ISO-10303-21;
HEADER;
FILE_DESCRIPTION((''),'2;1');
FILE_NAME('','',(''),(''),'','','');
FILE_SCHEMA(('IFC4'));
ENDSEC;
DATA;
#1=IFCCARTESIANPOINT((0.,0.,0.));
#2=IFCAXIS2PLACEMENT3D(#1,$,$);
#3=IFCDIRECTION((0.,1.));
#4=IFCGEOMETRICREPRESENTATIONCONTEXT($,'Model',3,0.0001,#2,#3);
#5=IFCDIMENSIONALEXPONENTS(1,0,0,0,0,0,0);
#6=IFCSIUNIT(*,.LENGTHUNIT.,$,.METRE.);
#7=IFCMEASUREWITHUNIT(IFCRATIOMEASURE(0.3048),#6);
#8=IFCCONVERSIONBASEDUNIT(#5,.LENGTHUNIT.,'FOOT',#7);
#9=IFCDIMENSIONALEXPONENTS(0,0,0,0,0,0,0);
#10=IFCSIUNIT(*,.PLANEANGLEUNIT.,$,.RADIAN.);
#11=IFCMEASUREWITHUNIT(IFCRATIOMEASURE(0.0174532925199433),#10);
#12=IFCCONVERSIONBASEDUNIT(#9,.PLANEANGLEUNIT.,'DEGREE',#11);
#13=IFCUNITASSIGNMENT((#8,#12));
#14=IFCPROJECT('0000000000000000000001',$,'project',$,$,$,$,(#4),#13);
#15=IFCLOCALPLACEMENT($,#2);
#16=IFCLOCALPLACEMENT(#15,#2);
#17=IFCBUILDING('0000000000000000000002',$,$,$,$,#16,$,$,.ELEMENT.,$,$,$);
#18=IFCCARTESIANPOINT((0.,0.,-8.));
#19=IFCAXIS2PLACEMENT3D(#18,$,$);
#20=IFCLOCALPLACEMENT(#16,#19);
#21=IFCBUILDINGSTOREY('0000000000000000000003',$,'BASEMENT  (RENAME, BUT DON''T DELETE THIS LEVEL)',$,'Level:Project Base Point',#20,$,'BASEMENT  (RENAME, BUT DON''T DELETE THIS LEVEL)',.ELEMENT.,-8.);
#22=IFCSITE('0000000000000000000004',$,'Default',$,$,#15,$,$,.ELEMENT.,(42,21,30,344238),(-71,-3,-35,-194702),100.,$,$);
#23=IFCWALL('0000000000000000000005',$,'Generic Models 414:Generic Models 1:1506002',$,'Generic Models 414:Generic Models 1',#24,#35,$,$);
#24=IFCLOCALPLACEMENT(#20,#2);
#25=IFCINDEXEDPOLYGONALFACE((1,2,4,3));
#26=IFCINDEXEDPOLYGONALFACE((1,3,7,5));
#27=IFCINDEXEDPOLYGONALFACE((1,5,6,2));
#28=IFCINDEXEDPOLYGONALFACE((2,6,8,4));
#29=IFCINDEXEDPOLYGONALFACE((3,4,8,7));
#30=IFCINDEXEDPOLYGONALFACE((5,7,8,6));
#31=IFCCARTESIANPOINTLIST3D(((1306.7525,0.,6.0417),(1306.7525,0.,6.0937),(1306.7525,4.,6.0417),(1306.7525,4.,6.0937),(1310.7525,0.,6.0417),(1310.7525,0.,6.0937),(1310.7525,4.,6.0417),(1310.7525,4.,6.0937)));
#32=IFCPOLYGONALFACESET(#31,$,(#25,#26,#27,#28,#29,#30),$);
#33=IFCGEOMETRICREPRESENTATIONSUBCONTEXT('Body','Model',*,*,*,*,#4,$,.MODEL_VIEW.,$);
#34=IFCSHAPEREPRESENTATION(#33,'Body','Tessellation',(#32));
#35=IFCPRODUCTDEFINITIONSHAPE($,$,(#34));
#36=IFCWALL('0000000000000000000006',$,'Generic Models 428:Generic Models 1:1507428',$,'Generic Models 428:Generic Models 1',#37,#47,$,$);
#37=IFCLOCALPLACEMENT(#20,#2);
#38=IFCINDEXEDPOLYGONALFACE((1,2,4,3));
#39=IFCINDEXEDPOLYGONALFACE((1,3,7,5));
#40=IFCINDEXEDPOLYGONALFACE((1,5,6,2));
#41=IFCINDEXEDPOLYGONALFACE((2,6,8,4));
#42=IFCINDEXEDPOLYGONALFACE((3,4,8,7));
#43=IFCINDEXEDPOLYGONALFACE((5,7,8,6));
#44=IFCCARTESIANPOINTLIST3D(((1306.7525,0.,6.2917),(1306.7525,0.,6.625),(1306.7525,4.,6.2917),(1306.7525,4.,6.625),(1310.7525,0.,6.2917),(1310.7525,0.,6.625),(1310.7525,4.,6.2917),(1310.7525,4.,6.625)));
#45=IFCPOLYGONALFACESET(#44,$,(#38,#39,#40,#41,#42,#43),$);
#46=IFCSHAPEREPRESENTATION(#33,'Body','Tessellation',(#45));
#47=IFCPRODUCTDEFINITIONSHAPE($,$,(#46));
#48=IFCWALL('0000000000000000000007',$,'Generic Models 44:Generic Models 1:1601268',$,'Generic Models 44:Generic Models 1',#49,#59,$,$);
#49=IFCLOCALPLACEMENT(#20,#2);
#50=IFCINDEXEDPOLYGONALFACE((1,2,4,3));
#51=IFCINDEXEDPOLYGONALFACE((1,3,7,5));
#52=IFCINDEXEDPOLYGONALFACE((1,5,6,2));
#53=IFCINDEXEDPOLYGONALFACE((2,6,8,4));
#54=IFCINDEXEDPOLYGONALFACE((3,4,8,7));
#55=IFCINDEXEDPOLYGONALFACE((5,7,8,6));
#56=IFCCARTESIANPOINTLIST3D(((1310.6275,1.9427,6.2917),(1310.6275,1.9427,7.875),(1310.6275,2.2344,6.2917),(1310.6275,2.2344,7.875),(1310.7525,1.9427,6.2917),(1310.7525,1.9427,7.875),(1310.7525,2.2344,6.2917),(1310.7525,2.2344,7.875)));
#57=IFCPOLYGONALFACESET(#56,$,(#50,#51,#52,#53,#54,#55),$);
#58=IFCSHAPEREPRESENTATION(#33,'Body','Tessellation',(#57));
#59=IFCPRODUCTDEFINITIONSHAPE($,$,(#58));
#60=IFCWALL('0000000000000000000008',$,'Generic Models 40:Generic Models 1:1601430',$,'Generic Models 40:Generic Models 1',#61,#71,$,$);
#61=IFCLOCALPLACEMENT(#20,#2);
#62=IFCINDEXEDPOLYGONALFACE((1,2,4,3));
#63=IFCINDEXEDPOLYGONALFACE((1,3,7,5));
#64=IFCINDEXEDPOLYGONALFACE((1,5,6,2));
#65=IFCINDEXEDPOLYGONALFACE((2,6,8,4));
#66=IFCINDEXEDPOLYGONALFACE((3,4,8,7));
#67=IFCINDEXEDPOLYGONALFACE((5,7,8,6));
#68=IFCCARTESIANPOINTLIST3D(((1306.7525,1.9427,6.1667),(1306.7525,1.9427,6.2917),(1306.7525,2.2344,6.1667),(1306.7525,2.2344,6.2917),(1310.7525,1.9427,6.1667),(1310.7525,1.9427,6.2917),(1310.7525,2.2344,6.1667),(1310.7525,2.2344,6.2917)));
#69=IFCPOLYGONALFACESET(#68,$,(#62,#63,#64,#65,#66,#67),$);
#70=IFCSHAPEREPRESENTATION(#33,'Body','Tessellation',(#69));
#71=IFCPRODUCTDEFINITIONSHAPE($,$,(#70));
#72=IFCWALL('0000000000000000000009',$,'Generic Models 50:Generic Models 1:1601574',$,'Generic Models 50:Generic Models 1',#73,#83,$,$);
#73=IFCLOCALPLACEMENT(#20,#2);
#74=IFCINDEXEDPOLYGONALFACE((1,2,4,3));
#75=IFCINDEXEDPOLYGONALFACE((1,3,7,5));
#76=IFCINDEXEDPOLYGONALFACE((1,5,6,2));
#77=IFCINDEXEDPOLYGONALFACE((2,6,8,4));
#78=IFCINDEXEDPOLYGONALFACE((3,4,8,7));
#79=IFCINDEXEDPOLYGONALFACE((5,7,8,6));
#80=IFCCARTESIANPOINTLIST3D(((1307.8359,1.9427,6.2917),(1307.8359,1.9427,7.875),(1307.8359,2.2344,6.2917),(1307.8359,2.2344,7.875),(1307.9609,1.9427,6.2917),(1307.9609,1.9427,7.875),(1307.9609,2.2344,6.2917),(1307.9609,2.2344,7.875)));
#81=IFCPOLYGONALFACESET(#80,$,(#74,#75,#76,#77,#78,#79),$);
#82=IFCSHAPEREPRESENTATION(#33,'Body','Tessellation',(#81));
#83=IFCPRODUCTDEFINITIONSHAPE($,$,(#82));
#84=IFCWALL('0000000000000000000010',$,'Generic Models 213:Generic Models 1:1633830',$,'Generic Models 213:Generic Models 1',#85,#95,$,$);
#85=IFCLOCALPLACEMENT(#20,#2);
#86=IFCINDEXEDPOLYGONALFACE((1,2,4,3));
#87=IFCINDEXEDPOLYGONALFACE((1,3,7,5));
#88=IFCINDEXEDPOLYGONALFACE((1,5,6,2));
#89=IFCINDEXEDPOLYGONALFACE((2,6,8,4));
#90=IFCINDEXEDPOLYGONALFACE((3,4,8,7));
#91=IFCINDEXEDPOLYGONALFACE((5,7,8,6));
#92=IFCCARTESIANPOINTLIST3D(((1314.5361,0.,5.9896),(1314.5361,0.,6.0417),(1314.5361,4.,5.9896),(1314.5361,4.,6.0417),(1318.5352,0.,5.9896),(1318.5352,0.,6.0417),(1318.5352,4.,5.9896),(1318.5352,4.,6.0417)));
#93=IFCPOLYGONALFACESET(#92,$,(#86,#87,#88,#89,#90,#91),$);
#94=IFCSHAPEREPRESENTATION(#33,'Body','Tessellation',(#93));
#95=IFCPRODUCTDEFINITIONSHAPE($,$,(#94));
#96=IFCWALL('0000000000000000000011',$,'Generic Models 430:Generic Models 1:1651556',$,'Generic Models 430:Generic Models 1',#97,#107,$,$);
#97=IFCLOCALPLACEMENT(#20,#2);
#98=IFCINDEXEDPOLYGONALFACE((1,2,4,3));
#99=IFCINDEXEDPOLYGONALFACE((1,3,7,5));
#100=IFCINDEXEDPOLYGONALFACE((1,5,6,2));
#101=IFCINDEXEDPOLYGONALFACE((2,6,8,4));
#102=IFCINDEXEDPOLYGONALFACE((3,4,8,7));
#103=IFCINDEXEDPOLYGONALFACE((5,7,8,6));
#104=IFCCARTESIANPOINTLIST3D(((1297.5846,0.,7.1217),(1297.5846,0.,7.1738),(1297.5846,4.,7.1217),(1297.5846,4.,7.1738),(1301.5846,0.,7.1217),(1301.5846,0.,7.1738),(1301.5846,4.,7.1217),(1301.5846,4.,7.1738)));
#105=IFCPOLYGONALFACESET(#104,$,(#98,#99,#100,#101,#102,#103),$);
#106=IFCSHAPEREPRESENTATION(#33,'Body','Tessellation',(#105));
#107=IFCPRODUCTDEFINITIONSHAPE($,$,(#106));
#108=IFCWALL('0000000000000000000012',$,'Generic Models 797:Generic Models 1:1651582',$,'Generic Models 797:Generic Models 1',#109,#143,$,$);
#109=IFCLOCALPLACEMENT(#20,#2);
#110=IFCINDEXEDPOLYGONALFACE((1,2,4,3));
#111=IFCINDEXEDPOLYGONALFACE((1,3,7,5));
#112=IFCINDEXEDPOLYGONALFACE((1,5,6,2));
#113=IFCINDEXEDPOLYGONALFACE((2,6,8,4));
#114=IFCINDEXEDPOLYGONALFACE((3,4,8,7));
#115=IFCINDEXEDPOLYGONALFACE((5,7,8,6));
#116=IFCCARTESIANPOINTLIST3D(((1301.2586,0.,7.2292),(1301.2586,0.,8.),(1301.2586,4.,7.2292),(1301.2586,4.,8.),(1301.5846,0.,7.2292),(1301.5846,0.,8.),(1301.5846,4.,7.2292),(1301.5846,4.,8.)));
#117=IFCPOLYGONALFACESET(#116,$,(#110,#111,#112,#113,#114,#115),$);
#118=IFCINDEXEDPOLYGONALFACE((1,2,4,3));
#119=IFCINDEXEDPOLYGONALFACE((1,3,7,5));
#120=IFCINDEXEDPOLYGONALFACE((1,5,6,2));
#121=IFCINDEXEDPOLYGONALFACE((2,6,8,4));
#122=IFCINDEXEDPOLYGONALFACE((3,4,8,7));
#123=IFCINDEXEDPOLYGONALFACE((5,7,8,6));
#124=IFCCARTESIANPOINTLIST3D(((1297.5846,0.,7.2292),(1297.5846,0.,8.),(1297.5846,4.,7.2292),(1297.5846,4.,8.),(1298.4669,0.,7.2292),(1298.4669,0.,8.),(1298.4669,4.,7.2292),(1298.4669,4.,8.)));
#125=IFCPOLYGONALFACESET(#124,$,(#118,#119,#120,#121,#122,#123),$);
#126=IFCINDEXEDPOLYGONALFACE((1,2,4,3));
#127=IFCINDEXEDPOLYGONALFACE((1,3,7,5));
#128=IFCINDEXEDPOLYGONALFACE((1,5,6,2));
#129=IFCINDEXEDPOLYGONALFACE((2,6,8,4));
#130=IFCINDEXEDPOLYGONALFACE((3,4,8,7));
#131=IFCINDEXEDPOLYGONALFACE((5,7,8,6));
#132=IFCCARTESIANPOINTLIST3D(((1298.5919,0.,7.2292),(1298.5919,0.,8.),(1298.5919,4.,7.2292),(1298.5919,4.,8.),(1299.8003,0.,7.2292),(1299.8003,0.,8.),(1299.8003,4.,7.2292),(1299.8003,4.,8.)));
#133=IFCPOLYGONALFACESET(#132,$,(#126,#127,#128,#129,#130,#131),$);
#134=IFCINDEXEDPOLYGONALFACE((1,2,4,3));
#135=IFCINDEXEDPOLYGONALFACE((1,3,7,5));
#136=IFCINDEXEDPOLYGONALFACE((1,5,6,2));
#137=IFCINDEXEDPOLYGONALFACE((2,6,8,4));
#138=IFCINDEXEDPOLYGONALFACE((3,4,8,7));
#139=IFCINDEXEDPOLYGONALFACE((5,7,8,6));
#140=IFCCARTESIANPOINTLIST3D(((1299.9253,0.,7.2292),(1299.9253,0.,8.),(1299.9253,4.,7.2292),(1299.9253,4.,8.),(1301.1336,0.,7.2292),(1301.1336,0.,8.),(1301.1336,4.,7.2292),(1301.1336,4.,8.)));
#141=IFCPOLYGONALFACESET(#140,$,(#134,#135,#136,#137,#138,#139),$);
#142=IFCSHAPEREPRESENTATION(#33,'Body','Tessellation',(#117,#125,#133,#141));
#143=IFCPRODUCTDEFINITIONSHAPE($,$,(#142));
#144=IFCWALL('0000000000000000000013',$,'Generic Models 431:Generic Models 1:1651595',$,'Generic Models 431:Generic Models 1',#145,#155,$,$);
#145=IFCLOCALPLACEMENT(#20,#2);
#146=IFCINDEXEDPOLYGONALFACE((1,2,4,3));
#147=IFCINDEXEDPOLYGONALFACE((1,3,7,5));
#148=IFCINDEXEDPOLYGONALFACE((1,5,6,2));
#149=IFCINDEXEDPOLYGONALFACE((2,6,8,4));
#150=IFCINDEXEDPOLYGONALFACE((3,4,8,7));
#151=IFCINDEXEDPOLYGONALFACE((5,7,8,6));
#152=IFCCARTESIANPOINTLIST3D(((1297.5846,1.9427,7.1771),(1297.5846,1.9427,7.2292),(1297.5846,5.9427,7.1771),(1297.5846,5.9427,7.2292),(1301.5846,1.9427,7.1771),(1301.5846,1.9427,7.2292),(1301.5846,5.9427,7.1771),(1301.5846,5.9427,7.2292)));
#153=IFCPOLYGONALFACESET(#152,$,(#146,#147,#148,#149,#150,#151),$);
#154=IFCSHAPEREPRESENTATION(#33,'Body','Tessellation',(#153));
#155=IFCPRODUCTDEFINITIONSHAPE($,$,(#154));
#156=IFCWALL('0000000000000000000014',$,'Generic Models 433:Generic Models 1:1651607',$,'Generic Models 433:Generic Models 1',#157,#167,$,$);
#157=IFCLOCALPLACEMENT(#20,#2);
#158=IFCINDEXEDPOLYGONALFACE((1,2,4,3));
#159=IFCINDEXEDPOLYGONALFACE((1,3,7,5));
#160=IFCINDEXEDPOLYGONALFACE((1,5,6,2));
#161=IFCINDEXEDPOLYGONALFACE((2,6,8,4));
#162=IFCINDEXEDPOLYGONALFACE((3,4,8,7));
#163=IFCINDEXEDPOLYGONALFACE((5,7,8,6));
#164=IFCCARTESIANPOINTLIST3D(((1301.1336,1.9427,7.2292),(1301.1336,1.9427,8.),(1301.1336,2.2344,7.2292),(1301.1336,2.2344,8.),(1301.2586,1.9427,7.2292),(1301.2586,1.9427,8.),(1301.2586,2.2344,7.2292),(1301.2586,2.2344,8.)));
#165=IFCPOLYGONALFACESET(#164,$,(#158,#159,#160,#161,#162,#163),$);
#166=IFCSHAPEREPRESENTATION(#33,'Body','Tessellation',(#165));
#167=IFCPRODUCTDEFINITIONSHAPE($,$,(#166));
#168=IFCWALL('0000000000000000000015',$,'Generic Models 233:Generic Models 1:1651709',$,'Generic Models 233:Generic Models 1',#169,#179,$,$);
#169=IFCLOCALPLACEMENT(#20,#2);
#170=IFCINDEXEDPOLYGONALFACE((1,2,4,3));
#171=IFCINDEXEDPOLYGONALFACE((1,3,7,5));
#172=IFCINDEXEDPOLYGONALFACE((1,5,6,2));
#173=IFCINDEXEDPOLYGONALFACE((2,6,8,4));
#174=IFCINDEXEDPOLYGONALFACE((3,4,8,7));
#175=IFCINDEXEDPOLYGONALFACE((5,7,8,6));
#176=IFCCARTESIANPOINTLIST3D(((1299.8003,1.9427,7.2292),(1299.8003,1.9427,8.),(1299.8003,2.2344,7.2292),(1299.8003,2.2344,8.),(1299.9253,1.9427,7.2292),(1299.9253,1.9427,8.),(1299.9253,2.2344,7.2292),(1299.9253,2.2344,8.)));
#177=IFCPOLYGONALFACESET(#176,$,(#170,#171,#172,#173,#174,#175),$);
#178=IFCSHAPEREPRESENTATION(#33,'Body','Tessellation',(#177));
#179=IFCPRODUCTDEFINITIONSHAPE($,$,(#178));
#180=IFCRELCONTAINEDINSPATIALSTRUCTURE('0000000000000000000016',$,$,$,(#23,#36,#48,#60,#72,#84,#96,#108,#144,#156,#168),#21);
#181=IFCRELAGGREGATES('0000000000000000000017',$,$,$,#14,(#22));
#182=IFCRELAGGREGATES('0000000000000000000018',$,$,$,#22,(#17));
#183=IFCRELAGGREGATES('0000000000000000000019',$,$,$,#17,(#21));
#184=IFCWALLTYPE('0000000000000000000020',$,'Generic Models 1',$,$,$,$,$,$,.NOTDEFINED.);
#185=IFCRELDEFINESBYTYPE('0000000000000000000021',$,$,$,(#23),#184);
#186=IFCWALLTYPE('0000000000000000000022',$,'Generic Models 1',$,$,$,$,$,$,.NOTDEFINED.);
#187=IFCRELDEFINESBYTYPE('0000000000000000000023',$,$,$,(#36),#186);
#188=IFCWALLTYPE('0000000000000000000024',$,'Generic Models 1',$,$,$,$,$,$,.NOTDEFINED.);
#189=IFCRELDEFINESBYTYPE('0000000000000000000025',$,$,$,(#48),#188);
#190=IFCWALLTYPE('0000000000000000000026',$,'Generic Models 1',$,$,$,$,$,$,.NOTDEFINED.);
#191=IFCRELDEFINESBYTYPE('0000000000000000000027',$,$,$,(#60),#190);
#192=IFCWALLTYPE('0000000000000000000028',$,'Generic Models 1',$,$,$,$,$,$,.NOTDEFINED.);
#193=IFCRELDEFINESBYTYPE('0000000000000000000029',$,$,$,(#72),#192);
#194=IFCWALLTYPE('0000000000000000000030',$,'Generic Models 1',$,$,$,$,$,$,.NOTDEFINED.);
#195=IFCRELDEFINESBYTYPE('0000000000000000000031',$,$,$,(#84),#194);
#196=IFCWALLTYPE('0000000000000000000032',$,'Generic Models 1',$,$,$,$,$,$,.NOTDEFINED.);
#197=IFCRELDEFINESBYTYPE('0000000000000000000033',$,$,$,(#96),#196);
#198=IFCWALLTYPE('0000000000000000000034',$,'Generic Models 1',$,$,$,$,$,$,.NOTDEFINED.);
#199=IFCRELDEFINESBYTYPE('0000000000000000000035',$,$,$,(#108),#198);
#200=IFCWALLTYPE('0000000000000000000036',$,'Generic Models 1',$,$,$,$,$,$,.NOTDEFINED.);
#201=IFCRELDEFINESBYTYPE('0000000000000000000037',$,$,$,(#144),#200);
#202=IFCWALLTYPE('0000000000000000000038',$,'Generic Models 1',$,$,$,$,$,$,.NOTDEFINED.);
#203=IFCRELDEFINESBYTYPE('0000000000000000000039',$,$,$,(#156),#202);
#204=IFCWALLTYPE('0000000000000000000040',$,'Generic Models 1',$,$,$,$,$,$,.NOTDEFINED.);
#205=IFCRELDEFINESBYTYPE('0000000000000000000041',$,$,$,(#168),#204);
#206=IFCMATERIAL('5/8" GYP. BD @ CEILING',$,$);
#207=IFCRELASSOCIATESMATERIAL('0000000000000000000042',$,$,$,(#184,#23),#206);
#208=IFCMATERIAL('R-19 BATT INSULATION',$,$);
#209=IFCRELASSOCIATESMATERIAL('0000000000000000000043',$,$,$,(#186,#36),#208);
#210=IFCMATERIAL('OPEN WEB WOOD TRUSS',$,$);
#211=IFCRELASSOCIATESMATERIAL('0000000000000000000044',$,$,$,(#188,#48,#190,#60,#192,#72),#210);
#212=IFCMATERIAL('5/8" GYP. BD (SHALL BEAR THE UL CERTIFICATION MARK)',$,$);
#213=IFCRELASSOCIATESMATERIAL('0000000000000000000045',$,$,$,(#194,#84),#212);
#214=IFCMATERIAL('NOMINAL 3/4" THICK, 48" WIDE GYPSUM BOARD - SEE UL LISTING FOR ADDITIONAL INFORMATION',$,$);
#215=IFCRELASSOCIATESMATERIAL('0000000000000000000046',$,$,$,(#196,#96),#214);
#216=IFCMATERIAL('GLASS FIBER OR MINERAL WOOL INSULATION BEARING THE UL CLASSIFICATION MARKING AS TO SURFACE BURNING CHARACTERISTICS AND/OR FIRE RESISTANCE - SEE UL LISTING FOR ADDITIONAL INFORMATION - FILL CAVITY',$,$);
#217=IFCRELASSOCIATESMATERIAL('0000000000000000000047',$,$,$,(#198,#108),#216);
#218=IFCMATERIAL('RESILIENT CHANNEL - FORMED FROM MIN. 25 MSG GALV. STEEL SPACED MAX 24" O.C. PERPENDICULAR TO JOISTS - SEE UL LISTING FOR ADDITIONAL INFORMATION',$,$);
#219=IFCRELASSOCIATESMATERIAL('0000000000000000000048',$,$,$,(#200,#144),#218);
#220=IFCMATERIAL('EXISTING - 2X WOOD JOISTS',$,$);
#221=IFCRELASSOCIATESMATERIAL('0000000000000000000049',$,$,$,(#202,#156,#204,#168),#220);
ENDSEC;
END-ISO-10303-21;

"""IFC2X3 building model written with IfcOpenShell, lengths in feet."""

from ifc_helpers import new_model, entity, si_unit, converted_unit, direction, frame, frame_2d, origin, origin_2d_with_axis, place, context, subcontext, project, spatial, rectangle, extrude, material, type_object, element, save


model = new_model("IFC2X3")

# Units and contexts
model_context = context("Model", 3, precision=0.0001, world=origin(), true_north=direction((0.0, 1.0)))
body_context = subcontext(model_context, "Body", "Model", "MODEL_VIEW")
ifc_project = project(units=[converted_unit("LENGTHUNIT", "FOOT", entity("IfcRatioMeasure", 0.3048), si_unit("LENGTHUNIT", "METRE"), dimensions=[1, 0, 0, 0, 0, 0, 0]), converted_unit("PLANEANGLEUNIT", "DEGREE", entity("IfcRatioMeasure", 0.0174532925199433), si_unit("PLANEANGLEUNIT", "RADIAN"), dimensions=[0, 0, 0, 0, 0, 0, 0])], contexts=[model_context])

# Site, building, storey
site_placement = place(None, origin())
site = spatial("IfcSite", under=ifc_project, at=site_placement, Name="Default", CompositionType="ELEMENT", RefLatitude=(42, 21, 30, 344238), RefLongitude=(-71, -3, -35, -194702), RefElevation=100.0)
building_placement = place(site_placement, origin())
building = spatial("IfcBuilding", under=site, at=building_placement, CompositionType="ELEMENT")
storey_placement = place(building_placement, frame((0.0, 0.0, -8.0)))
storey = spatial("IfcBuildingStorey", under=building, at=storey_placement, Name="BASEMENT  (RENAME, BUT DON'T DELETE THIS LEVEL)", ObjectType="Level:Project Base Point", LongName="BASEMENT  (RENAME, BUT DON'T DELETE THIS LEVEL)", CompositionType="ELEMENT", Elevation=-8.0)

# Walls
ifc_material_1 = material(Name="5/8\" GYP. BD @ CEILING")
wall_type_1 = type_object("IfcWallType", Name="Generic Models 1", PredefinedType="NOTDEFINED", material=ifc_material_1)
wall_1_placement = place(storey_placement, frame((1306.7525, 0.0, 6.0417), z_axis=(0.0, 0.0, 1.0), x_axis=(0.0, 1.0, 0.0)))
element("IfcWall", 1, at=wall_1_placement, inside=storey, type_object=wall_type_1, material=ifc_material_1, Name="Generic Models 414:Generic Models 1:1506002", ObjectType="Generic Models 414:Generic Models 1", context=body_context, shape_type="SweptSolid", body=[
    extrude(rectangle(XDim=4.0, YDim=4.0, at=origin_2d_with_axis()), frame((2.0, -2.0, 0.0)), (0.0, 0.0, 1.0), 0.0521),
])
ifc_material_2 = material(Name="R-19 BATT INSULATION")
wall_type_2 = type_object("IfcWallType", Name="Generic Models 1", PredefinedType="NOTDEFINED", material=ifc_material_2)
wall_2_placement = place(storey_placement, frame((1306.7525, 0.0, 6.2917), z_axis=(0.0, 0.0, 1.0), x_axis=(0.0, 1.0, 0.0)))
element("IfcWall", 2, at=wall_2_placement, inside=storey, type_object=wall_type_2, material=ifc_material_2, Name="Generic Models 428:Generic Models 1:1507428", ObjectType="Generic Models 428:Generic Models 1", context=body_context, shape_type="SweptSolid", body=[
    extrude(rectangle(XDim=4.0, YDim=4.0, at=origin_2d_with_axis()), frame((2.0, -2.0, 0.0)), (0.0, 0.0, 1.0), 0.3333),
])
ifc_material_3 = material(Name="OPEN WEB WOOD TRUSS")
wall_type_3 = type_object("IfcWallType", Name="Generic Models 1", PredefinedType="NOTDEFINED", material=ifc_material_3)
wall_3_placement = place(storey_placement, frame((1310.6275, 1.9427, 6.2917), z_axis=(0.0, 0.0, 1.0), x_axis=(0.0, 1.0, 0.0)))
element("IfcWall", 3, at=wall_3_placement, inside=storey, type_object=wall_type_3, material=ifc_material_3, Name="Generic Models 44:Generic Models 1:1601268", ObjectType="Generic Models 44:Generic Models 1", context=body_context, shape_type="SweptSolid", body=[
    extrude(rectangle(XDim=0.2917, YDim=0.125, at=frame_2d((0.0, 0.0), x_axis=(1.0, 0.0))), frame((0.1458, -0.0625, 0.0)), (0.0, 0.0, 1.0), 1.5833),
])
wall_type_4 = type_object("IfcWallType", Name="Generic Models 1", PredefinedType="NOTDEFINED", material=ifc_material_3)
wall_4_placement = place(storey_placement, frame((1306.7525, 1.9427, 6.1667)))
element("IfcWall", 4, at=wall_4_placement, inside=storey, type_object=wall_type_4, material=ifc_material_3, Name="Generic Models 40:Generic Models 1:1601430", ObjectType="Generic Models 40:Generic Models 1", context=body_context, shape_type="SweptSolid", body=[
    extrude(rectangle(XDim=0.2917, YDim=4.0, at=frame_2d((0.0, 0.0), x_axis=(1.0, 0.0))), frame((2.0, 0.1458, 0.0), z_axis=(0.0, 0.0, 1.0), x_axis=(0.0, 1.0, 0.0)), (0.0, 0.0, 1.0), 0.125),
])
wall_type_5 = type_object("IfcWallType", Name="Generic Models 1", PredefinedType="NOTDEFINED", material=ifc_material_3)
wall_5_placement = place(storey_placement, frame((1307.8359, 1.9427, 6.2917), z_axis=(0.0, 0.0, 1.0), x_axis=(0.0, 1.0, 0.0)))
element("IfcWall", 5, at=wall_5_placement, inside=storey, type_object=wall_type_5, material=ifc_material_3, Name="Generic Models 50:Generic Models 1:1601574", ObjectType="Generic Models 50:Generic Models 1", context=body_context, shape_type="SweptSolid", body=[
    extrude(rectangle(XDim=0.2917, YDim=0.125, at=frame_2d((0.0, 0.0), x_axis=(1.0, 0.0))), frame((0.1458, -0.0625, 0.0)), (0.0, 0.0, 1.0), 1.5833),
])
ifc_material_4 = material(Name="5/8\" GYP. BD (SHALL BEAR THE UL CERTIFICATION MARK)")
wall_type_6 = type_object("IfcWallType", Name="Generic Models 1", PredefinedType="NOTDEFINED", material=ifc_material_4)
wall_6_placement = place(storey_placement, frame((1314.5361, 0.0, 5.9896), z_axis=(0.0, 0.0, 1.0), x_axis=(0.0, 1.0, 0.0)))
element("IfcWall", 6, at=wall_6_placement, inside=storey, type_object=wall_type_6, material=ifc_material_4, Name="Generic Models 213:Generic Models 1:1633830", ObjectType="Generic Models 213:Generic Models 1", context=body_context, shape_type="SweptSolid", body=[
    extrude(rectangle(XDim=4.0, YDim=3.999, at=origin_2d_with_axis()), frame((2.0, -1.9995, 0.0)), (0.0, 0.0, 1.0), 0.0521),
])
ifc_material_5 = material(Name="NOMINAL 3/4\" THICK, 48\" WIDE GYPSUM BOARD - SEE UL LISTING FOR ADDITIONAL INFORMATION")
wall_type_7 = type_object("IfcWallType", Name="Generic Models 1", PredefinedType="NOTDEFINED", material=ifc_material_5)
wall_7_placement = place(storey_placement, frame((1297.5846, 0.0, 7.1217), z_axis=(0.0, 0.0, 1.0), x_axis=(0.0, 1.0, 0.0)))
element("IfcWall", 7, at=wall_7_placement, inside=storey, type_object=wall_type_7, material=ifc_material_5, Name="Generic Models 430:Generic Models 1:1651556", ObjectType="Generic Models 430:Generic Models 1", context=body_context, shape_type="SweptSolid", body=[
    extrude(rectangle(XDim=4.0, YDim=4.0, at=origin_2d_with_axis()), frame((2.0, -2.0, 0.0)), (0.0, 0.0, 1.0), 0.0521),
])
ifc_material_6 = material(Name="GLASS FIBER OR MINERAL WOOL INSULATION BEARING THE UL CLASSIFICATION MARKING AS TO SURFACE BURNING CHARACTERISTICS AND/OR FIRE RESISTANCE - SEE UL LISTING FOR ADDITIONAL INFORMATION - FILL CAVITY")
wall_type_8 = type_object("IfcWallType", Name="Generic Models 1", PredefinedType="NOTDEFINED", material=ifc_material_6)
wall_8_placement = place(storey_placement, frame((1297.5846, 0.0, 7.2292), z_axis=(0.0, 0.0, 1.0), x_axis=(0.0, 1.0, 0.0)))
element("IfcWall", 8, at=wall_8_placement, inside=storey, type_object=wall_type_8, material=ifc_material_6, Name="Generic Models 797:Generic Models 1:1651582", ObjectType="Generic Models 797:Generic Models 1", context=body_context, shape_type="SweptSolid", body=[
    extrude(rectangle(XDim=4.0, YDim=0.326, at=origin_2d_with_axis()), frame((2.0, -3.837, 0.0)), (0.0, 0.0, 1.0), 0.7708),
    extrude(rectangle(XDim=4.0, YDim=0.8824, at=origin_2d_with_axis()), frame((2.0, -0.4412, 0.0)), (0.0, 0.0, 1.0), 0.7708),
    extrude(rectangle(XDim=4.0, YDim=1.2083, at=frame_2d((0.0, 0.0), x_axis=(1.0, 0.0))), frame((2.0, -1.6115, 0.0)), (0.0, 0.0, 1.0), 0.7708),
    extrude(rectangle(XDim=4.0, YDim=1.2083, at=frame_2d((0.0, 0.0), x_axis=(1.0, 0.0))), frame((2.0, -2.9449, 0.0)), (0.0, 0.0, 1.0), 0.7708),
])
ifc_material_7 = material(Name="RESILIENT CHANNEL - FORMED FROM MIN. 25 MSG GALV. STEEL SPACED MAX 24\" O.C. PERPENDICULAR TO JOISTS - SEE UL LISTING FOR ADDITIONAL INFORMATION")
wall_type_9 = type_object("IfcWallType", Name="Generic Models 1", PredefinedType="NOTDEFINED", material=ifc_material_7)
wall_9_placement = place(storey_placement, frame((1297.5846, 1.9427, 7.1771), z_axis=(0.0, 0.0, 1.0), x_axis=(0.0, 1.0, 0.0)))
element("IfcWall", 9, at=wall_9_placement, inside=storey, type_object=wall_type_9, material=ifc_material_7, Name="Generic Models 431:Generic Models 1:1651595", ObjectType="Generic Models 431:Generic Models 1", context=body_context, shape_type="SweptSolid", body=[
    extrude(rectangle(XDim=4.0, YDim=4.0, at=frame_2d((0.0, 0.0), x_axis=(1.0, 0.0))), frame((2.0, -2.0, 0.0)), (0.0, 0.0, 1.0), 0.0521),
])
ifc_material_8 = material(Name="EXISTING - 2X WOOD JOISTS")
wall_type_10 = type_object("IfcWallType", Name="Generic Models 1", PredefinedType="NOTDEFINED", material=ifc_material_8)
wall_10_placement = place(storey_placement, frame((1301.1336, 1.9427, 7.2292), z_axis=(0.0, 0.0, 1.0), x_axis=(0.0, 1.0, 0.0)))
element("IfcWall", 10, at=wall_10_placement, inside=storey, type_object=wall_type_10, material=ifc_material_8, Name="Generic Models 433:Generic Models 1:1651607", ObjectType="Generic Models 433:Generic Models 1", context=body_context, shape_type="SweptSolid", body=[
    extrude(rectangle(XDim=0.2917, YDim=0.125, at=frame_2d((0.0, 0.0), x_axis=(1.0, 0.0))), frame((0.1458, -0.0625, 0.0)), (0.0, 0.0, 1.0), 0.7708),
])
wall_type_11 = type_object("IfcWallType", Name="Generic Models 1", PredefinedType="NOTDEFINED", material=ifc_material_8)
wall_11_placement = place(storey_placement, frame((1299.8003, 1.9427, 7.2292), z_axis=(0.0, 0.0, 1.0), x_axis=(0.0, 1.0, 0.0)))
element("IfcWall", 11, at=wall_11_placement, inside=storey, type_object=wall_type_11, material=ifc_material_8, Name="Generic Models 233:Generic Models 1:1651709", ObjectType="Generic Models 233:Generic Models 1", context=body_context, shape_type="SweptSolid", body=[
    extrude(rectangle(XDim=0.2917, YDim=0.125, at=frame_2d((0.0, 0.0), x_axis=(1.0, 0.0))), frame((0.1458, -0.0625, 0.0)), (0.0, 0.0, 1.0), 0.7708),
])

save(model, "model.ifc")
